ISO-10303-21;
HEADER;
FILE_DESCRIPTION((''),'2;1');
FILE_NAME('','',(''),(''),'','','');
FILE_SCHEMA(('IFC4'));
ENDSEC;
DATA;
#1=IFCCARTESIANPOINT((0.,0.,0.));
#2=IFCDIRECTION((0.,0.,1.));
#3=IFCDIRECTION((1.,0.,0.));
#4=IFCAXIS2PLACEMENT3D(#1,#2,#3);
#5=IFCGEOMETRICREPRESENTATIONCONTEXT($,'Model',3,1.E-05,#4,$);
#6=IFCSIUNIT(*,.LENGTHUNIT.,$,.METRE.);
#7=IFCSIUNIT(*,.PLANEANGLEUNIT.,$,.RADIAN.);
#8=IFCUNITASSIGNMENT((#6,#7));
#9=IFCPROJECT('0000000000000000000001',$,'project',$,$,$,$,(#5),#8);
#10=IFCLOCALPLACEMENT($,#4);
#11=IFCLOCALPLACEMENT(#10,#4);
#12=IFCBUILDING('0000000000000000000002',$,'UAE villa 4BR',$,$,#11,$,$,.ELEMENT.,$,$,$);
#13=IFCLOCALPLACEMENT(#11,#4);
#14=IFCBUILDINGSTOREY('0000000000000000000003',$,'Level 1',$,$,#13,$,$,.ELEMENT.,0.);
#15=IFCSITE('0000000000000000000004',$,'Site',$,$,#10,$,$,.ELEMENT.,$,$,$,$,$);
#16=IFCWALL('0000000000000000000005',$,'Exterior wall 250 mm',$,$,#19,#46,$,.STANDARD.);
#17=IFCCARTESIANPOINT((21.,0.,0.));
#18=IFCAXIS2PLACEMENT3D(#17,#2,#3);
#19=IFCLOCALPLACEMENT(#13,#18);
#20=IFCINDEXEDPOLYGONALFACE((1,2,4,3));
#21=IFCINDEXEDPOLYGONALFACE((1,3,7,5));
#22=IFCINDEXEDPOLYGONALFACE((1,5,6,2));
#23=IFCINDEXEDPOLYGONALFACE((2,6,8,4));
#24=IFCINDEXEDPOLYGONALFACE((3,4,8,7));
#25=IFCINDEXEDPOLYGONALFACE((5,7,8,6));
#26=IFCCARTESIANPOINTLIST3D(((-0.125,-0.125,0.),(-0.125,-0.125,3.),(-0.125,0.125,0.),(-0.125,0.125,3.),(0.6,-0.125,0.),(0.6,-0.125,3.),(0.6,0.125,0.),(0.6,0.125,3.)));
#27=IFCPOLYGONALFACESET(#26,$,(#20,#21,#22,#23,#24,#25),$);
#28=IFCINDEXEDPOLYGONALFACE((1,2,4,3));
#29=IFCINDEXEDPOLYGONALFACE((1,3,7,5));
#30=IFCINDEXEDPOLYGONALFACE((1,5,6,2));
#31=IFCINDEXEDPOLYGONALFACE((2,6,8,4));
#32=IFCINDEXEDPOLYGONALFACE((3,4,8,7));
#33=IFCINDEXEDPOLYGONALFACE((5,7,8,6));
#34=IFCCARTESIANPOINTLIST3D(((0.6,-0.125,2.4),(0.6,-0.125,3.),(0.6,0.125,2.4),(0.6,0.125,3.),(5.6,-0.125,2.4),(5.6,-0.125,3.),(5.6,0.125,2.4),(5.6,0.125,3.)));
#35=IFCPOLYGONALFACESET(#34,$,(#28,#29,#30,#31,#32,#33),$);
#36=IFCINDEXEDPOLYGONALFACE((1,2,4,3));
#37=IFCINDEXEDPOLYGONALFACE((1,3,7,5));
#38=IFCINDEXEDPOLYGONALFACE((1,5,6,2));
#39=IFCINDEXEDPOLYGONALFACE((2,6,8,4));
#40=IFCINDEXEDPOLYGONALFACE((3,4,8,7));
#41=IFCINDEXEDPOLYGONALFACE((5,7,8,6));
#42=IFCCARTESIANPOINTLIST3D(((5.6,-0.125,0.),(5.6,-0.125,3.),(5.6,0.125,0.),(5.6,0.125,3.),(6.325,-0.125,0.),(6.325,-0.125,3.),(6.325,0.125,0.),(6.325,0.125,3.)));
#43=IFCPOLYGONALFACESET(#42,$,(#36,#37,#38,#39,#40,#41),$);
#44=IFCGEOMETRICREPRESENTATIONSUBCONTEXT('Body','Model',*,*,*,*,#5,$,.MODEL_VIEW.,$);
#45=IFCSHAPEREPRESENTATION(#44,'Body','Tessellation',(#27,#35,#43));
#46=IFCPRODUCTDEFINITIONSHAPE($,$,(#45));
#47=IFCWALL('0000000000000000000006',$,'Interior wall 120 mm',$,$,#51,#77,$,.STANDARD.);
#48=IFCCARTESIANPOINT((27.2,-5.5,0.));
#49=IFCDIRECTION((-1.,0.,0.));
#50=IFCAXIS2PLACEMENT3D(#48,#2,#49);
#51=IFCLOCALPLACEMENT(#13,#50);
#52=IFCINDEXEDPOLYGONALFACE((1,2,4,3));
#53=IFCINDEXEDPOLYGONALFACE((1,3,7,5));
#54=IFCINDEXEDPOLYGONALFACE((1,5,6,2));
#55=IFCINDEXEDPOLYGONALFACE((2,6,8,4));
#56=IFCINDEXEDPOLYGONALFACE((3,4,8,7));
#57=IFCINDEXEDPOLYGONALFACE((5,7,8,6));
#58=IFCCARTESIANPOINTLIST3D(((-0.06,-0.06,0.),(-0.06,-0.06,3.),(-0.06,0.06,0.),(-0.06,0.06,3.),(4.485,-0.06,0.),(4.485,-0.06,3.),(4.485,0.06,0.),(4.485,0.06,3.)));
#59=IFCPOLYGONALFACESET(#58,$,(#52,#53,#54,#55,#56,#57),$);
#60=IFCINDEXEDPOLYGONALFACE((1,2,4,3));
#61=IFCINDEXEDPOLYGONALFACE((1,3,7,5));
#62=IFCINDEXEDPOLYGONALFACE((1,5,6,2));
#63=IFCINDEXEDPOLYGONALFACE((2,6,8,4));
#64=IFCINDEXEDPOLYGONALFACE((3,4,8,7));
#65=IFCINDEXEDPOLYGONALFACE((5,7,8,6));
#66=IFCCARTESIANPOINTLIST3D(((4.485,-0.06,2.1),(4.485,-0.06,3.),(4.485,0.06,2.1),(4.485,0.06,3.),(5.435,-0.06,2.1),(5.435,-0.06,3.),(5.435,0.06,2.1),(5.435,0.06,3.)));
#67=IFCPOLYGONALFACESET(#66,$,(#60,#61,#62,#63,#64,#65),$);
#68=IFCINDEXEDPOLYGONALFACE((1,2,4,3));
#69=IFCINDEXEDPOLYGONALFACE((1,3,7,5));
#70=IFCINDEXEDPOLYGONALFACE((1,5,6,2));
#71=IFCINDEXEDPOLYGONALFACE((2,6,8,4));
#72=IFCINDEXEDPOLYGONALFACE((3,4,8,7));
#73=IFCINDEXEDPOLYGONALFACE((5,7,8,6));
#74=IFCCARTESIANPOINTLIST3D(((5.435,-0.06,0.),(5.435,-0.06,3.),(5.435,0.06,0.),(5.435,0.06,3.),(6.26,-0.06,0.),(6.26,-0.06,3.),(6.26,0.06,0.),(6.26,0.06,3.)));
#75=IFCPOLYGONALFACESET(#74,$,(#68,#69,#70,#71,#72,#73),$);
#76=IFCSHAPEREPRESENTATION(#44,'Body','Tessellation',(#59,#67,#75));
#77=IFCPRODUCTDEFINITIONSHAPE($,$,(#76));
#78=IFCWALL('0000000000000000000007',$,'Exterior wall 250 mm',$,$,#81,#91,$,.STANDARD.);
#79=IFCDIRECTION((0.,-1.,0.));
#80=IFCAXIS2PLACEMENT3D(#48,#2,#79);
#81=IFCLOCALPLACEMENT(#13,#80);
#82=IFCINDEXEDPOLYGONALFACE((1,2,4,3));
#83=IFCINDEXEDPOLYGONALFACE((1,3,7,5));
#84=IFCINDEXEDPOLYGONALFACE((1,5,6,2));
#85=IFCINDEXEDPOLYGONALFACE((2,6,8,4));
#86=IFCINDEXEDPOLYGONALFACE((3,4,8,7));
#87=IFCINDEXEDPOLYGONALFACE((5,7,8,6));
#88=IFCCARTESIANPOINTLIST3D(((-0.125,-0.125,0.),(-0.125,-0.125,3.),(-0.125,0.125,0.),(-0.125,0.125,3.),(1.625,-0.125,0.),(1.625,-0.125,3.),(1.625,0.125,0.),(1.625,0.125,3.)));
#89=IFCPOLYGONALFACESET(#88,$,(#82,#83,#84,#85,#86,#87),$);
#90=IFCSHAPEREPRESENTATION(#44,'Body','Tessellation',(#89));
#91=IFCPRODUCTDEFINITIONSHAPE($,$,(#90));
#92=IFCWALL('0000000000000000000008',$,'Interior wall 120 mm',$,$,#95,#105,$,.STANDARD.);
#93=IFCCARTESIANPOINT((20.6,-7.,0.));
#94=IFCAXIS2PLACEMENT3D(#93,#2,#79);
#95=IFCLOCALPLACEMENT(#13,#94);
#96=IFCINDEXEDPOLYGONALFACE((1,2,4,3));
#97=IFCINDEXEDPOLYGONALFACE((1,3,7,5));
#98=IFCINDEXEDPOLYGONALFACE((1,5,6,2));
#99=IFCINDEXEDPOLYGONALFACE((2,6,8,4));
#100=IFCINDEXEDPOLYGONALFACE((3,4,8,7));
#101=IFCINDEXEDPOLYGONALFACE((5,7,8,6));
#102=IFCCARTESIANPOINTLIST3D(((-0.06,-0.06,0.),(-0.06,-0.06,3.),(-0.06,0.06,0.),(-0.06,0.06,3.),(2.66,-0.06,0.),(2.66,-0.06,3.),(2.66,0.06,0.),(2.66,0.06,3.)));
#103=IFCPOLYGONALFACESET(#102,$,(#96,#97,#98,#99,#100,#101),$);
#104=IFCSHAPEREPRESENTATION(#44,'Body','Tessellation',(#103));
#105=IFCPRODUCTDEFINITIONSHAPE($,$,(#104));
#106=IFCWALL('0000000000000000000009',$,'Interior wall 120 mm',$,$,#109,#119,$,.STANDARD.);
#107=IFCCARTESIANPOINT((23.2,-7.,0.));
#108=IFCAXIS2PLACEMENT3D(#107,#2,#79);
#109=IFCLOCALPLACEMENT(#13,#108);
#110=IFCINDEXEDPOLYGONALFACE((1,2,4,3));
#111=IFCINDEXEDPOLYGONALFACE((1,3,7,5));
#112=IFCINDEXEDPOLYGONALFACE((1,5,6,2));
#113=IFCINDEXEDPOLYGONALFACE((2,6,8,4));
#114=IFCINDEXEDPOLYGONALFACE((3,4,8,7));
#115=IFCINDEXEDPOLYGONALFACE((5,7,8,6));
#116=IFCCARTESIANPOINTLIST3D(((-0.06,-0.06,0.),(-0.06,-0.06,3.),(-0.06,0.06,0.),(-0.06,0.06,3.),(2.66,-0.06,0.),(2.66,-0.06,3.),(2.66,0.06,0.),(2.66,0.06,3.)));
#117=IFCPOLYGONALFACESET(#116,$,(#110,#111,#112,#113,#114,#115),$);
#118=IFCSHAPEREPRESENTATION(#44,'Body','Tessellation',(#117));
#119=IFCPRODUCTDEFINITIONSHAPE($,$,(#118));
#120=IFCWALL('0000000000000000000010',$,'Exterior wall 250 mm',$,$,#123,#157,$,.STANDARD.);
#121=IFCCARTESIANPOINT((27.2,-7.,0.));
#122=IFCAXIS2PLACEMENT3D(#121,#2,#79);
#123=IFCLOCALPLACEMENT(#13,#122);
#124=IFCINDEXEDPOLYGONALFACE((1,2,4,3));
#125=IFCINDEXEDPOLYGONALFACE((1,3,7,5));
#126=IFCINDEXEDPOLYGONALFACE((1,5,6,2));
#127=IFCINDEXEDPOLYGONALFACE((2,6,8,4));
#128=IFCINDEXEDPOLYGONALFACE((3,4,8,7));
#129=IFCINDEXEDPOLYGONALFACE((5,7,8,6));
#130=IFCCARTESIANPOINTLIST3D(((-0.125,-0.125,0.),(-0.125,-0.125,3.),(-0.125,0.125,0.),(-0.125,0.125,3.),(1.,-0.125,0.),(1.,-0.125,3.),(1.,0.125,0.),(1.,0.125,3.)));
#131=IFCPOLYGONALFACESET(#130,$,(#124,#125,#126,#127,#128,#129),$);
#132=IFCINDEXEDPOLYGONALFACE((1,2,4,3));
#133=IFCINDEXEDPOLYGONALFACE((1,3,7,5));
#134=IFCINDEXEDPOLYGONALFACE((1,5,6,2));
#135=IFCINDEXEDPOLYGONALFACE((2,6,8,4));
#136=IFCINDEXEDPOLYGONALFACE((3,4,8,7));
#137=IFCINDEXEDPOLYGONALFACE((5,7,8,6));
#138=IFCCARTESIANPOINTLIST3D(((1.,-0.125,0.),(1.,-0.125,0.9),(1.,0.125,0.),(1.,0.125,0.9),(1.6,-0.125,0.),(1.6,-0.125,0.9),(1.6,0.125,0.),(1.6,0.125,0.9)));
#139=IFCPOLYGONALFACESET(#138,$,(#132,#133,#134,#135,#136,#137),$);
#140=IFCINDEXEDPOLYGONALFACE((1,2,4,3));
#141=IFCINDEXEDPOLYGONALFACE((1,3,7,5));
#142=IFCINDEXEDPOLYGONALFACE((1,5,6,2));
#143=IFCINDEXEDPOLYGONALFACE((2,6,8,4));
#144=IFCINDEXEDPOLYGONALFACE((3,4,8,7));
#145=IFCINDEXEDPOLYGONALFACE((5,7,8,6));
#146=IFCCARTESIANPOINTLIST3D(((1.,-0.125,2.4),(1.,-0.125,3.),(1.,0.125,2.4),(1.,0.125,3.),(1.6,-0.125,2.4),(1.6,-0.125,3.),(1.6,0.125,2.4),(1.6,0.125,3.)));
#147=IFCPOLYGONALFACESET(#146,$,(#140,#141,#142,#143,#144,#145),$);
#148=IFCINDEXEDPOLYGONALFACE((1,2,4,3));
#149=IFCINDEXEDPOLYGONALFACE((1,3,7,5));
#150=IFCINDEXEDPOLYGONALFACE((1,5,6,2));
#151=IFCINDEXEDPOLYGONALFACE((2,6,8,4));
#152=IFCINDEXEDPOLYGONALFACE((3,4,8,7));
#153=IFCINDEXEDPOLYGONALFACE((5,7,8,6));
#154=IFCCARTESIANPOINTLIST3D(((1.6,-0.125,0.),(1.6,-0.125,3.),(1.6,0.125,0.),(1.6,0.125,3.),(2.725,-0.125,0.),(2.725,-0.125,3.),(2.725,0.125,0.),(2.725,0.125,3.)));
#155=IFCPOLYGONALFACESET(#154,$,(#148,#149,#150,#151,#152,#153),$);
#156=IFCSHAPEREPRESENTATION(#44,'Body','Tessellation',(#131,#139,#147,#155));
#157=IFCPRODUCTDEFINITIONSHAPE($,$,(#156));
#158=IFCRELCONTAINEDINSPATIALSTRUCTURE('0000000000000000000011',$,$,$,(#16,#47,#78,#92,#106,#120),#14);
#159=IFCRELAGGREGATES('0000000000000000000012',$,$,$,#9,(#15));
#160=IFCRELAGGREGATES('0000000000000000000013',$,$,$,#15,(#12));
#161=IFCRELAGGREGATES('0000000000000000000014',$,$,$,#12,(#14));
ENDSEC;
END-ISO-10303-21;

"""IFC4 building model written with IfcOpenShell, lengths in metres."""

from ifc_helpers import new_model, si_unit, frame, origin_with_axes, origin_2d, place, context, subcontext, project, spatial, rectangle, extrude, element, save


model = new_model("IFC4")

# Units and contexts
model_context = context("Model", 3, precision=1e-05, world=origin_with_axes())
body_context = subcontext(model_context, "Body", "Model", "MODEL_VIEW")
ifc_project = project(units=[si_unit("LENGTHUNIT", "METRE"), si_unit("PLANEANGLEUNIT", "RADIAN")], contexts=[model_context])

# Site, building, storey
site_placement = place(None, origin_with_axes())
site = spatial("IfcSite", under=ifc_project, at=site_placement, Name="Site", CompositionType="ELEMENT")
building_placement = place(site_placement, origin_with_axes())
building = spatial("IfcBuilding", under=site, at=building_placement, Name="UAE villa 4BR", CompositionType="ELEMENT")
storey_placement = place(building_placement, origin_with_axes())
storey = spatial("IfcBuildingStorey", under=building, at=storey_placement, Name="Level 1", CompositionType="ELEMENT", Elevation=0.0)

# Walls
wall_1_placement = place(storey_placement, frame((21.0, 0.0, 0.0), z_axis=(0.0, 0.0, 1.0), x_axis=(1.0, 0.0, 0.0)))
element("IfcWall", 1, at=wall_1_placement, inside=storey, Name="Exterior wall 250 mm", PredefinedType="STANDARD", context=body_context, shape_type="SweptSolid", body=[
    extrude(rectangle(XDim=0.725, YDim=0.25, at=origin_2d()), frame((0.2375, 0.0, 0.0)), (0.0, 0.0, 1.0), 3.0),
    extrude(rectangle(XDim=5.0, YDim=0.25, at=origin_2d()), frame((3.1, 0.0, 2.4)), (0.0, 0.0, 1.0), 0.6),
    extrude(rectangle(XDim=0.725, YDim=0.25, at=origin_2d()), frame((5.9625, 0.0, 0.0)), (0.0, 0.0, 1.0), 3.0),
])
wall_2_placement = place(storey_placement, frame((27.2, -5.5, 0.0), z_axis=(0.0, 0.0, 1.0), x_axis=(-1.0, 0.0, 0.0)))
element("IfcWall", 2, at=wall_2_placement, inside=storey, Name="Interior wall 120 mm", PredefinedType="STANDARD", context=body_context, shape_type="SweptSolid", body=[
    extrude(rectangle(XDim=4.545, YDim=0.12, at=origin_2d()), frame((2.2125, 0.0, 0.0)), (0.0, 0.0, 1.0), 3.0),
    extrude(rectangle(XDim=0.95, YDim=0.12, at=origin_2d()), frame((4.96, 0.0, 2.1)), (0.0, 0.0, 1.0), 0.9),
    extrude(rectangle(XDim=0.825, YDim=0.12, at=origin_2d()), frame((5.8475, 0.0, 0.0)), (0.0, 0.0, 1.0), 3.0),
])
wall_3_placement = place(storey_placement, frame((27.2, -5.5, 0.0), z_axis=(0.0, 0.0, 1.0), x_axis=(0.0, -1.0, 0.0)))
element("IfcWall", 3, at=wall_3_placement, inside=storey, Name="Exterior wall 250 mm", PredefinedType="STANDARD", context=body_context, shape_type="SweptSolid", body=[
    extrude(rectangle(XDim=1.75, YDim=0.25, at=origin_2d()), frame((0.75, 0.0, 0.0)), (0.0, 0.0, 1.0), 3.0),
])
for number, where, z_axis, x_axis, name in (
    (4, (20.6, -7.0, 0.0), (0.0, 0.0, 1.0), (0.0, -1.0, 0.0), "Interior wall 120 mm"),
    (5, (23.2, -7.0, 0.0), (0.0, 0.0, 1.0), (0.0, -1.0, 0.0), "Interior wall 120 mm"),
):
    element("IfcWall", number, at=place(storey_placement, frame(where, z_axis=z_axis, x_axis=x_axis)), inside=storey, Name=name, PredefinedType="STANDARD", context=body_context, shape_type="SweptSolid", body=[
        extrude(rectangle(XDim=2.72, YDim=0.12, at=origin_2d()), frame((1.3, 0.0, 0.0)), (0.0, 0.0, 1.0), 3.0),
    ])
wall_4_placement = place(storey_placement, frame((27.2, -7.0, 0.0), z_axis=(0.0, 0.0, 1.0), x_axis=(0.0, -1.0, 0.0)))
element("IfcWall", 6, at=wall_4_placement, inside=storey, Name="Exterior wall 250 mm", PredefinedType="STANDARD", context=body_context, shape_type="SweptSolid", body=[
    extrude(rectangle(XDim=1.125, YDim=0.25, at=origin_2d()), frame((0.4375, 0.0, 0.0)), (0.0, 0.0, 1.0), 3.0),
    extrude(rectangle(XDim=0.6, YDim=0.25, at=origin_2d()), frame((1.3, 0.0, 0.0)), (0.0, 0.0, 1.0), 0.9),
    extrude(rectangle(XDim=0.6, YDim=0.25, at=origin_2d()), frame((1.3, 0.0, 2.4)), (0.0, 0.0, 1.0), 0.6),
    extrude(rectangle(XDim=1.125, YDim=0.25, at=origin_2d()), frame((2.1625, 0.0, 0.0)), (0.0, 0.0, 1.0), 3.0),
])

save(model, "model.ifc")
